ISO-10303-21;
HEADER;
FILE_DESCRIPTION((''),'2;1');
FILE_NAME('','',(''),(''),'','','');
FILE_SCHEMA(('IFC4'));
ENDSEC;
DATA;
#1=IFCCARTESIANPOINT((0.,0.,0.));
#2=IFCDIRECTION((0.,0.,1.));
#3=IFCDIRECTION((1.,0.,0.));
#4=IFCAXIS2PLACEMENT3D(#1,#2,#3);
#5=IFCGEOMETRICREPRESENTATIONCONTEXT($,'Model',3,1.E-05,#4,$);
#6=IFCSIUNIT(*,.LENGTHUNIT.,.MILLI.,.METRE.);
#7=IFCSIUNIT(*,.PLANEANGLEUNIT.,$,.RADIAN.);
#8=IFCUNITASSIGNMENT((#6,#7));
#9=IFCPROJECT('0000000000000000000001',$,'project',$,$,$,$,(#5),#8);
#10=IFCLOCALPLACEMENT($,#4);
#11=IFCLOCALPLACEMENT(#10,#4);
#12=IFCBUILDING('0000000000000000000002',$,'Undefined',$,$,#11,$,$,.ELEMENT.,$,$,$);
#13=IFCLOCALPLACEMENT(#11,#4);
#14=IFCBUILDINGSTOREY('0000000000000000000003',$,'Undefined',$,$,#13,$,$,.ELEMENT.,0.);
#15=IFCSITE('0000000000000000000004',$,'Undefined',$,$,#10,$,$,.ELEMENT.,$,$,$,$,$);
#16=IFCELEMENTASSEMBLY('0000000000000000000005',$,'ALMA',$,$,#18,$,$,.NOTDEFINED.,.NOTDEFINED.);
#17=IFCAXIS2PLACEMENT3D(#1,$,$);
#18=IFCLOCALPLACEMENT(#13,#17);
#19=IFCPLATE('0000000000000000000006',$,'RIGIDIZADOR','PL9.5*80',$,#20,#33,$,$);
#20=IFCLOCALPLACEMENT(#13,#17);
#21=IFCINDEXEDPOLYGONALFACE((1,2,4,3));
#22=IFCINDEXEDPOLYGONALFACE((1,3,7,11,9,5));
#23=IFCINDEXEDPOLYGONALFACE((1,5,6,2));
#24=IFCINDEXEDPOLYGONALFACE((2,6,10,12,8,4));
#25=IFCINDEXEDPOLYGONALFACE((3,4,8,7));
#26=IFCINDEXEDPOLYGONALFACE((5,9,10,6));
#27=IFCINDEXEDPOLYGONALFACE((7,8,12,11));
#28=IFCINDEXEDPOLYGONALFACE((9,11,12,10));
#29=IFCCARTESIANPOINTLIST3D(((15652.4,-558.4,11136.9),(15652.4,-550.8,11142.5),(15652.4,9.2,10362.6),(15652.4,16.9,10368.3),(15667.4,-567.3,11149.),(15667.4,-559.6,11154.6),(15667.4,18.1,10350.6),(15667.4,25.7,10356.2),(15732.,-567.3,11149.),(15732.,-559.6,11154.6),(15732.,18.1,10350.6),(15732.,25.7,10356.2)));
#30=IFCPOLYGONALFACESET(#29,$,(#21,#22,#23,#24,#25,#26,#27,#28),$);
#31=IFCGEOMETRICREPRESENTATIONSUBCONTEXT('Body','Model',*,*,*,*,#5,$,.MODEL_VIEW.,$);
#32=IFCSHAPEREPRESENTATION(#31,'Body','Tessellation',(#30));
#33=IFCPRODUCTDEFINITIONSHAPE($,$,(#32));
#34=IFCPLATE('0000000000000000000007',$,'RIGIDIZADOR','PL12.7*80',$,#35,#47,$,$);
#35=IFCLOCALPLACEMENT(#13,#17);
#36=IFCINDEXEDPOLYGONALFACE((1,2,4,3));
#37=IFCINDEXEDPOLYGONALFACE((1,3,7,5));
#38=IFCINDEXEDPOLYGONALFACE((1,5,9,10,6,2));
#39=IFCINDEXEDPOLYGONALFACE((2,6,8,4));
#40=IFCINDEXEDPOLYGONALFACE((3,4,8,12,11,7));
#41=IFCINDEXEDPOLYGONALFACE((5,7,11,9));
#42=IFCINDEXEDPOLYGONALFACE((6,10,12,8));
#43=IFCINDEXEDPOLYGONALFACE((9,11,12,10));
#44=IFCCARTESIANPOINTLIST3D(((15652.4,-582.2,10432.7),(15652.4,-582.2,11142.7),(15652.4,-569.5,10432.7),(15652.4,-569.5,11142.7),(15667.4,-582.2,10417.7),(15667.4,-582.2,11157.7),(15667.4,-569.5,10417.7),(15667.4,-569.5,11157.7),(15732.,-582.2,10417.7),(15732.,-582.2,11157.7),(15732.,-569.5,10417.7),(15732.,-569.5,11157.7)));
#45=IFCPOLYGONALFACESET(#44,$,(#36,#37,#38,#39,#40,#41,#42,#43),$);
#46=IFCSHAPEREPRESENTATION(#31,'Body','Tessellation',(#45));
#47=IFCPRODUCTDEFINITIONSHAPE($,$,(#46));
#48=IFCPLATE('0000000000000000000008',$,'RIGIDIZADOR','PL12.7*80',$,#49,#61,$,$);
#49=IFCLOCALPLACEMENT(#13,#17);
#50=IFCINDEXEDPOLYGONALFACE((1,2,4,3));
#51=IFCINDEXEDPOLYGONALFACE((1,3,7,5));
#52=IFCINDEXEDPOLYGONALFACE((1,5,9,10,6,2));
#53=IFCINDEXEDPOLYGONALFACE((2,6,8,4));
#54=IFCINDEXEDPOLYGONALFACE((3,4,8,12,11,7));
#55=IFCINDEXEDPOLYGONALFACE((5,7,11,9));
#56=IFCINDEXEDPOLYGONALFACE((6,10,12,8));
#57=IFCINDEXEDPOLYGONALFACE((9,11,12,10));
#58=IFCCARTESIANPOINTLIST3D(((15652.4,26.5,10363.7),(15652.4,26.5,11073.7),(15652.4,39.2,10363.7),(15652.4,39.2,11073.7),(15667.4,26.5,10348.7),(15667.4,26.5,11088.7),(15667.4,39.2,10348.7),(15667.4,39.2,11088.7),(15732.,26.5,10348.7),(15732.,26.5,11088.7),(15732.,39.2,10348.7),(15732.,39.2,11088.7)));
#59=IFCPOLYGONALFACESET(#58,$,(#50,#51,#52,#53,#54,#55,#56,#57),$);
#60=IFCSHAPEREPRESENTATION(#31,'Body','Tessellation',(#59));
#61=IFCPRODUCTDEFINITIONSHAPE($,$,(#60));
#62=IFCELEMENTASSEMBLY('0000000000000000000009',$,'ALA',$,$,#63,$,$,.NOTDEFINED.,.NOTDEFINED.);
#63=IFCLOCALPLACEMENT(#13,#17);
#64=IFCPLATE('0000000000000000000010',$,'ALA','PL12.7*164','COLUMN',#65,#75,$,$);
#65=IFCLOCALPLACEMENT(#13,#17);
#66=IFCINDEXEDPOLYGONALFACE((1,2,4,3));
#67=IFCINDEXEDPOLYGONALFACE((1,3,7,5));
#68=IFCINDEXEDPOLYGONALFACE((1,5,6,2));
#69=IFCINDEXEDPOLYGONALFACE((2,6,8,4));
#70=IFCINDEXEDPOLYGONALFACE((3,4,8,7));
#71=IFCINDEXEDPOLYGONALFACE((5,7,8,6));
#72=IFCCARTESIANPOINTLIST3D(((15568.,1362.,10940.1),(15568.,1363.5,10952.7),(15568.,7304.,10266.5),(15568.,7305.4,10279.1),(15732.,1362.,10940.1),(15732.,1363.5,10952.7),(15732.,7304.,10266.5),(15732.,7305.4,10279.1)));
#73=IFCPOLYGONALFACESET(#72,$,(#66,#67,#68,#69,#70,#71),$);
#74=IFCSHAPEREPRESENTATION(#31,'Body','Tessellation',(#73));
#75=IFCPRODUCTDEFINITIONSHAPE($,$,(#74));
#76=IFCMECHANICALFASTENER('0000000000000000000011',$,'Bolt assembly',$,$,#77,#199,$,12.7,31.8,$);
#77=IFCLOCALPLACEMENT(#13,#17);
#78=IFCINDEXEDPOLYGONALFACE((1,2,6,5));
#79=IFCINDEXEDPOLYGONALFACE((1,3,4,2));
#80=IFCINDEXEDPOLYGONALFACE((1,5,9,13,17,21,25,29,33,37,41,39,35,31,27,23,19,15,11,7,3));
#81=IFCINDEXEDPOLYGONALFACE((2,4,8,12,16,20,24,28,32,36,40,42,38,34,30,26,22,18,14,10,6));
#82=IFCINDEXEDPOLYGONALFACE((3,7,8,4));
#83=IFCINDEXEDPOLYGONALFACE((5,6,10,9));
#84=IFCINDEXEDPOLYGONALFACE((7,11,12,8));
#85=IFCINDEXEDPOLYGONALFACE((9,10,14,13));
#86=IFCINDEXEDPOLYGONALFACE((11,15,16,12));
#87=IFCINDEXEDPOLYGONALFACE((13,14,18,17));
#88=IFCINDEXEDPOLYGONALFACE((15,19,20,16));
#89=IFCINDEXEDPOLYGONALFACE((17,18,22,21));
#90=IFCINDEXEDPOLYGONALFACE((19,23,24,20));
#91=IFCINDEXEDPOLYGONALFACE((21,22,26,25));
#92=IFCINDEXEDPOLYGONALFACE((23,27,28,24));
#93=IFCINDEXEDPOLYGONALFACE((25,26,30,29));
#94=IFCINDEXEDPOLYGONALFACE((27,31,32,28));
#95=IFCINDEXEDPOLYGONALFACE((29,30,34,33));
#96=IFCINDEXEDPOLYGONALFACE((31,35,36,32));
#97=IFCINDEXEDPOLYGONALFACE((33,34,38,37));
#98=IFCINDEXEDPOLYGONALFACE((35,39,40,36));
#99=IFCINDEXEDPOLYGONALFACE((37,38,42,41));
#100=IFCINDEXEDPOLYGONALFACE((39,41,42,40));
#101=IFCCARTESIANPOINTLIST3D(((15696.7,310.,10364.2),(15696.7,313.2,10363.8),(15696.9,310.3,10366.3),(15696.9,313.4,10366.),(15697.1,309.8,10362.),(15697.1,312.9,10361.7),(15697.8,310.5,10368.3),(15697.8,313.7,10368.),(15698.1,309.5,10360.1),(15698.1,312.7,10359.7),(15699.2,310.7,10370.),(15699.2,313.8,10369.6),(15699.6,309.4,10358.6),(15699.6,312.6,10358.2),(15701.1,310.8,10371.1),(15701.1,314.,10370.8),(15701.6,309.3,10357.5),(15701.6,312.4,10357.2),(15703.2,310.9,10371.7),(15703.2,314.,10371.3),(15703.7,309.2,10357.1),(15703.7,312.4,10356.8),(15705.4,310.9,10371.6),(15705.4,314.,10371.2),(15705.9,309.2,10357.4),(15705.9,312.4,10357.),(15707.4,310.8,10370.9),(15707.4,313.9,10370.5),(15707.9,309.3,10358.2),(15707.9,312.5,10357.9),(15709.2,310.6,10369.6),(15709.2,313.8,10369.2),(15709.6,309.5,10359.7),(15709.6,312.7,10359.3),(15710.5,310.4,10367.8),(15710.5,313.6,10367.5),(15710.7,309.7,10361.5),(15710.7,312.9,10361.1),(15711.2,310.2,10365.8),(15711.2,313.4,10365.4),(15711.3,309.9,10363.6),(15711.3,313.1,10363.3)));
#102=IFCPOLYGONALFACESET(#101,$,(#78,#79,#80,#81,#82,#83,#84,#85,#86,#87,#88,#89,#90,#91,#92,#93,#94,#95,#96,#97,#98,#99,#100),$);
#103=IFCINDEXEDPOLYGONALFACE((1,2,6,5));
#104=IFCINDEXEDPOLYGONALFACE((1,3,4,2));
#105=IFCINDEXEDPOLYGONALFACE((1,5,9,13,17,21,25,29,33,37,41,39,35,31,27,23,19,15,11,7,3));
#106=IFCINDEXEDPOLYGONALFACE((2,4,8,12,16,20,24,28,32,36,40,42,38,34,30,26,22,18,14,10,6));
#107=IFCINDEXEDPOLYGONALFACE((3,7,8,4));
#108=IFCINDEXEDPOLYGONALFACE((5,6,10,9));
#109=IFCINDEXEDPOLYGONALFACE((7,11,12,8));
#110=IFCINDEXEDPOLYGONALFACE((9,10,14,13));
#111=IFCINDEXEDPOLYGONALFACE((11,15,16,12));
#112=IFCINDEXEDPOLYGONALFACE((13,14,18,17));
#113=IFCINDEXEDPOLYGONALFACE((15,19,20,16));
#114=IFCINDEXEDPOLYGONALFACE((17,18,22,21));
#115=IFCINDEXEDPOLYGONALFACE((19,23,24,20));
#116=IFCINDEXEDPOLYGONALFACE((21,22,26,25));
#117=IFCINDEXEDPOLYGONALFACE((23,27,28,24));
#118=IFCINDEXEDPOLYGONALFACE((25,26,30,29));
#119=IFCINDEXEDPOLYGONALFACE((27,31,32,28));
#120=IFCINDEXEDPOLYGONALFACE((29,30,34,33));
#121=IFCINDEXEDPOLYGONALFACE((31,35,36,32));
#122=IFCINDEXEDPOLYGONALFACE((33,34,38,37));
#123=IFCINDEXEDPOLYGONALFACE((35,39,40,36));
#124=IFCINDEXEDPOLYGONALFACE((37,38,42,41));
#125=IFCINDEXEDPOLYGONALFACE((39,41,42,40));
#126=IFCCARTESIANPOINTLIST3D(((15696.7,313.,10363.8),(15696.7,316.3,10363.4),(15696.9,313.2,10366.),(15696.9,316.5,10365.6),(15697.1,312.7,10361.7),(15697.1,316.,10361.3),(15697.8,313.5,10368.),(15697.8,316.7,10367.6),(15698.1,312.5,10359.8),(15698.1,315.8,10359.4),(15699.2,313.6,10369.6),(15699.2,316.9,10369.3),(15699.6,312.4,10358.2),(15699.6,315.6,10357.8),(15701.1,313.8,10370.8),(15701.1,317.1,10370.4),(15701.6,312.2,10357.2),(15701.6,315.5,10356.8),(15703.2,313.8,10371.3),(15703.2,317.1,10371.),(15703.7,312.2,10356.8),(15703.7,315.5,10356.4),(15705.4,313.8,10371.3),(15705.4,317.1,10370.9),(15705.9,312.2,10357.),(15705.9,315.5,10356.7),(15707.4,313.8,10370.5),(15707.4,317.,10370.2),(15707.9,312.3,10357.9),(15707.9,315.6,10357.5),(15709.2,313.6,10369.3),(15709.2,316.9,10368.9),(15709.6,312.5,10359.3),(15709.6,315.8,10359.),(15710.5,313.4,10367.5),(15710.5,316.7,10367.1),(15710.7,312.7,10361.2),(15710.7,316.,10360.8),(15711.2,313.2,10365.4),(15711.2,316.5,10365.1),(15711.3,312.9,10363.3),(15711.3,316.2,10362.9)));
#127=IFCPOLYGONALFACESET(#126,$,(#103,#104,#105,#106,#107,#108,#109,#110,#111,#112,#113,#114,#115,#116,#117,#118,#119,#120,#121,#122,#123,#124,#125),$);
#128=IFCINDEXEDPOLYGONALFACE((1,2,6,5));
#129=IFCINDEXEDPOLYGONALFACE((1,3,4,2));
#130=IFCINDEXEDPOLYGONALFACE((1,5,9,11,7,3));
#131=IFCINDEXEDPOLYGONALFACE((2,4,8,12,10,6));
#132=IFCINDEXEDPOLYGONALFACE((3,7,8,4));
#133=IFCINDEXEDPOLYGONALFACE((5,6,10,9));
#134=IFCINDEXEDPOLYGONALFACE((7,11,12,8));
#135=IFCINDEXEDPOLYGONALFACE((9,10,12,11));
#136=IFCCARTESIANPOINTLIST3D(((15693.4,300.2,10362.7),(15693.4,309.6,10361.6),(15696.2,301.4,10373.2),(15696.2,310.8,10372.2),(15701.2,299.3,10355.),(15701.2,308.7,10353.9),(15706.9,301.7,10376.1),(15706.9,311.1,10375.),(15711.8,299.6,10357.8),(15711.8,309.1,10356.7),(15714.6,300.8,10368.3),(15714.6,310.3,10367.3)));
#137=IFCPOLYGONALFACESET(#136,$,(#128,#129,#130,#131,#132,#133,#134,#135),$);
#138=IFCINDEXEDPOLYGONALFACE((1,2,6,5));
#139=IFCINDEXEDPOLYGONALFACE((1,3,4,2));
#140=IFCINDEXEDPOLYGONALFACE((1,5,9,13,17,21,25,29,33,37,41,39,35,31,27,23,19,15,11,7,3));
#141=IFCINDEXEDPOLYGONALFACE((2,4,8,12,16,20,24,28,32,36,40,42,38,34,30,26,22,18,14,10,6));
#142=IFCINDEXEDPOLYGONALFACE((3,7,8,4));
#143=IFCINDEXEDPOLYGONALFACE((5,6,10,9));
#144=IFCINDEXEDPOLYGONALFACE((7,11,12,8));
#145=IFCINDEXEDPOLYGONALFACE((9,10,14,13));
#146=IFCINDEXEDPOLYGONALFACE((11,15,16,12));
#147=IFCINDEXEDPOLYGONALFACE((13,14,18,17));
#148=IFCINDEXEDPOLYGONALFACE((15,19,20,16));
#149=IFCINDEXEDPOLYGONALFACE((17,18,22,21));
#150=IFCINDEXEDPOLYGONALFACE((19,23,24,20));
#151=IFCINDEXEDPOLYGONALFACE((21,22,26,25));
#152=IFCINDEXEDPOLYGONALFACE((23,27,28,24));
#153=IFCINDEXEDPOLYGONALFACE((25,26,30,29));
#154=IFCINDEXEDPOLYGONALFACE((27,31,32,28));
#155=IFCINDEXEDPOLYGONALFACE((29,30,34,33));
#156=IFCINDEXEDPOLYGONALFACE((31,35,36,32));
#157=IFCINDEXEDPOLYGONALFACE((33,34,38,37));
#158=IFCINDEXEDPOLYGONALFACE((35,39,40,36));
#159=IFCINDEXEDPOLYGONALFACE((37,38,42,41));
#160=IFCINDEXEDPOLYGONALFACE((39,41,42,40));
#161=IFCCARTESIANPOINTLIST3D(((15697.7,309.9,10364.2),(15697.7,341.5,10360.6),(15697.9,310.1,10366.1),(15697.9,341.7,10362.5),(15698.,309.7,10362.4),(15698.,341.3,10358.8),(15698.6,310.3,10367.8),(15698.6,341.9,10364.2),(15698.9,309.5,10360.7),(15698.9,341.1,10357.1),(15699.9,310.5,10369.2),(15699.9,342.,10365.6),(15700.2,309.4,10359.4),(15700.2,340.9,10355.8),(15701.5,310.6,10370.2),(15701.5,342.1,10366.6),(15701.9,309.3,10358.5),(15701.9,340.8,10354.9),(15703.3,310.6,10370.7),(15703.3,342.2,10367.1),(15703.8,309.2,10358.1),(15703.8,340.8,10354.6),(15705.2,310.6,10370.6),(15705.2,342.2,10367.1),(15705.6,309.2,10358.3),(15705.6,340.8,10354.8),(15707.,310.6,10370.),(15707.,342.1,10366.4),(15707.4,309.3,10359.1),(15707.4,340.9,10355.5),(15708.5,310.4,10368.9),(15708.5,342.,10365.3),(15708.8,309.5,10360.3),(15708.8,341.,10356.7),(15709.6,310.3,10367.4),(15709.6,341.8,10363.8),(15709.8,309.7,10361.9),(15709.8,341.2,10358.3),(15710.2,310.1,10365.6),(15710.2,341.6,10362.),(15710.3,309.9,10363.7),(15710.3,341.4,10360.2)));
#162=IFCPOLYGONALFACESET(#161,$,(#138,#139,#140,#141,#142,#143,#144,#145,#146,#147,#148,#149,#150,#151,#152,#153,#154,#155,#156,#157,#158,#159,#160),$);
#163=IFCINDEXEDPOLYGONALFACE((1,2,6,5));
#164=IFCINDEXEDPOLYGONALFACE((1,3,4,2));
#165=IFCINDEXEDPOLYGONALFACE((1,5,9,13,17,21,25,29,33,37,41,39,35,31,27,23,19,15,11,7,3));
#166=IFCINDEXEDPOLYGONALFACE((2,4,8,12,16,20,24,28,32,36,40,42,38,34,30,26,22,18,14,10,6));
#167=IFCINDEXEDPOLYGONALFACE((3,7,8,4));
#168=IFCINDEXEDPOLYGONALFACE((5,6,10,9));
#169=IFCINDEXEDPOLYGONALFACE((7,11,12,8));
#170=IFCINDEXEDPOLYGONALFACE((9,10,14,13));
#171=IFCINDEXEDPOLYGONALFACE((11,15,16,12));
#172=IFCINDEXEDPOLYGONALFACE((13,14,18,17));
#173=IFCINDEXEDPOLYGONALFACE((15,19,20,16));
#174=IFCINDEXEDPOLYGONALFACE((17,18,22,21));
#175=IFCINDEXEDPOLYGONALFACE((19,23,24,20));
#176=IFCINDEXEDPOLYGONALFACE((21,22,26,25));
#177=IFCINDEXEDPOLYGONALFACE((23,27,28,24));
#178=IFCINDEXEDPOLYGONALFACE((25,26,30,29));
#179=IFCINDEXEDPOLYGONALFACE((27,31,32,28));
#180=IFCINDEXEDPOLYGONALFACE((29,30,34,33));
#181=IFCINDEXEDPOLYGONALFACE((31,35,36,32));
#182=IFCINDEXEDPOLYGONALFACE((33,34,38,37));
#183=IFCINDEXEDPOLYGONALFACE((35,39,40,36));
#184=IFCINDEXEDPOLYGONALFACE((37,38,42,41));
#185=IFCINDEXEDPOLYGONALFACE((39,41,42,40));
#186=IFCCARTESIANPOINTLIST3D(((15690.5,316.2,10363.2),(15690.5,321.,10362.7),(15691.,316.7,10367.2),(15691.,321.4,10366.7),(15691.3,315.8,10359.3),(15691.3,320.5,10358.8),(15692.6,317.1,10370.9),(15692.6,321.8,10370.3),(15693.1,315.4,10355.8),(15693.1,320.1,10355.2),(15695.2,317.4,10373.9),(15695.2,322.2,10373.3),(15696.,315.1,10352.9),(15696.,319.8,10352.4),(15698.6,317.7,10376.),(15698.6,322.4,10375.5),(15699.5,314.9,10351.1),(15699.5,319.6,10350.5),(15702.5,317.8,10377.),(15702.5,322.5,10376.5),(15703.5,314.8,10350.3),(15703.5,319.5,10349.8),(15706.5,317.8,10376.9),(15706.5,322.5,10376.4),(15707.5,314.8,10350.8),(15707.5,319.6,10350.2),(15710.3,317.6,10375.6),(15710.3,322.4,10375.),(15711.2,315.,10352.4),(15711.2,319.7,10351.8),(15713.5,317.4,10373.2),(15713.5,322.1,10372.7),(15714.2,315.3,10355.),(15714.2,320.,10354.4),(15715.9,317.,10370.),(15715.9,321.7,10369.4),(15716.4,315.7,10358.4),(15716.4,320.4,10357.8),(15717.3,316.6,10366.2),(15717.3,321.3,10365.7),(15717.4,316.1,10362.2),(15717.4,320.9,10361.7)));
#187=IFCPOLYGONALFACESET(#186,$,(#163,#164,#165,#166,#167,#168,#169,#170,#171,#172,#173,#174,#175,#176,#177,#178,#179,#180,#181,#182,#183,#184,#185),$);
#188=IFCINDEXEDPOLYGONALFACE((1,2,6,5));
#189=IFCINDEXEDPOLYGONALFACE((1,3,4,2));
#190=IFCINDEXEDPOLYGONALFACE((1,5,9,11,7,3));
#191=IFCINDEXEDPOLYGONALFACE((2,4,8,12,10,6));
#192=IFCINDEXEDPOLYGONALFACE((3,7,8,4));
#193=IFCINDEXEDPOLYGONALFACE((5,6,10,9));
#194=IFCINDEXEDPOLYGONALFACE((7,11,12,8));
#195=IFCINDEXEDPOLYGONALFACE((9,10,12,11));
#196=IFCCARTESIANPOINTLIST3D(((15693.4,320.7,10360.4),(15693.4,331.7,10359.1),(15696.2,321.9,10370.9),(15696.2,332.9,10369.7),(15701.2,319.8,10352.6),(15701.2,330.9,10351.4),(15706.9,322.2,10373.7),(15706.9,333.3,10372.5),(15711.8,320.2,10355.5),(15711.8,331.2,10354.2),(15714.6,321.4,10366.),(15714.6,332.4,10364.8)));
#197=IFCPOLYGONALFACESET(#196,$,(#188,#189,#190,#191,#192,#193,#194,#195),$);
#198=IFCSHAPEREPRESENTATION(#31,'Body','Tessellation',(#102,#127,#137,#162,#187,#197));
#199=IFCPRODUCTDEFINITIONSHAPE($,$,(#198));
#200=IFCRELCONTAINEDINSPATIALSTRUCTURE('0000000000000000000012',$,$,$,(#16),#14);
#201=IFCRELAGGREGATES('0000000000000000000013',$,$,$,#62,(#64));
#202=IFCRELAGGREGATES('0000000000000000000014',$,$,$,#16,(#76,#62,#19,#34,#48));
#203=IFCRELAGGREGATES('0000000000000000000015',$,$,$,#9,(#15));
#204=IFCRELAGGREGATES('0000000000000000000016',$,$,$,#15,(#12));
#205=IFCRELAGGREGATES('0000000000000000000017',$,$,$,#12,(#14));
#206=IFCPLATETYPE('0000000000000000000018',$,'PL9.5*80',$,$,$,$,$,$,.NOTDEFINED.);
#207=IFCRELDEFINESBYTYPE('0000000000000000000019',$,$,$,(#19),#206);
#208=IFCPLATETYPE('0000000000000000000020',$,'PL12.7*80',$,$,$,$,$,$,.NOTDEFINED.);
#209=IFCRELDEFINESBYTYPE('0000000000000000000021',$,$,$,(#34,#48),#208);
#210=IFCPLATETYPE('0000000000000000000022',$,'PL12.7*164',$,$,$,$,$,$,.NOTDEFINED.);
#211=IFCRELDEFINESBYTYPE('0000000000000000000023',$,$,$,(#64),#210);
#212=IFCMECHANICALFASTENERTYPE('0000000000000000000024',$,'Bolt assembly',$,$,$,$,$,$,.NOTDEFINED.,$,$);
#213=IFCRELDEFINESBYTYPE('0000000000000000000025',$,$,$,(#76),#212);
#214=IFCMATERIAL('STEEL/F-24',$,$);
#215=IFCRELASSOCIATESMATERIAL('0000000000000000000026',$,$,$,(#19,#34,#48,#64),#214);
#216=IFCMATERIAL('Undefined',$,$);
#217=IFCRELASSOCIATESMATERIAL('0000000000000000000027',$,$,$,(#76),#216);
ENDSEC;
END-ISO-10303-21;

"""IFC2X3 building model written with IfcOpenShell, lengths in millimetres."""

from ifc_helpers import new_model, si_unit, frame, origin_with_axes, origin_2d_with_axis, place, context, subcontext, project, spatial, polyline, circle, outline, extrude, source, transform, mapped, material, type_object, element, aggregate, save


model = new_model("IFC2X3")

# Units and contexts
model_context = context("Model", 3, precision=1e-05, world=origin_with_axes())
body_context = subcontext(model_context, "Body", "Model", "MODEL_VIEW")
ifc_project = project(units=[si_unit("LENGTHUNIT", "METRE", prefix="MILLI"), si_unit("PLANEANGLEUNIT", "RADIAN")], contexts=[model_context])

# Site, building, storey
site_placement = place(None, origin_with_axes())
site = spatial("IfcSite", under=ifc_project, at=site_placement, Name="Undefined", CompositionType="ELEMENT")
building_placement = place(site_placement, origin_with_axes())
building = spatial("IfcBuilding", under=site, at=building_placement, Name="Undefined", CompositionType="ELEMENT")
storey_placement = place(building_placement, origin_with_axes())
storey = spatial("IfcBuildingStorey", under=building, at=storey_placement, Name="Undefined", CompositionType="ELEMENT", Elevation=0.0)

# Shared definitions
ifc_material_1 = material(Name="STEEL/F-24")

# Element assembly
assembly_1_placement = place(storey_placement, origin_with_axes())
assembly_1 = element("IfcElementAssembly", 1, at=assembly_1_placement, inside=storey, Name="ALMA", AssemblyPlace="NOTDEFINED", PredefinedType="NOTDEFINED")

# Plates
plate_type_1 = type_object("IfcPlateType", Name="PL9.5*80", PredefinedType="NOTDEFINED")
plate_1_placement = place(assembly_1_placement, frame((15732.0, -563.5, 11151.8), z_axis=(0.0, 0.806474, 0.59127), x_axis=(0.0, 0.59127, -0.806474)))
plate_1 = element("IfcPlate", 2, at=plate_1_placement, type_object=plate_type_1, material=ifc_material_1, Name="RIGIDIZADOR", Description="PL9.5*80", context=body_context, shape_type="SweptSolid", body=[
    extrude(outline(polyline([(0.0, 0.0), (990.0, 0.0), (990.0, 64.6), (975.0, 79.6), (15.0, 79.6), (0.0, 64.6), (0.0, 0.0)])), frame((0.0, 0.0, -4.8), z_axis=(0.0, 0.0, 1.0), x_axis=(1.0, 0.0, 0.0)), (0.0, 0.0, 1.0), 9.5),
])
plate_type_2 = type_object("IfcPlateType", Name="PL12.7*80", PredefinedType="NOTDEFINED")
plate_2_placement = place(assembly_1_placement, frame((15732.0, -575.9, 11157.7), z_axis=(0.0, 1.0, 0.0), x_axis=(0.0, 0.0, -1.0)))
plate_2 = element("IfcPlate", 3, at=plate_2_placement, type_object=plate_type_2, material=ifc_material_1, Name="RIGIDIZADOR", Description="PL12.7*80", context=body_context, shape_type="SweptSolid", body=[
    extrude(outline(polyline([(0.0, 0.0), (740.0, 0.0), (740.0, 64.6), (725.0, 79.6), (15.0, 79.6), (0.0, 64.6), (0.0, 0.0)])), frame((0.0, 0.0, -6.3), z_axis=(0.0, 0.0, 1.0), x_axis=(1.0, 0.0, 0.0)), (0.0, 0.0, 1.0), 12.7),
])
plate_3_placement = place(assembly_1_placement, frame((15732.0, 32.9, 11088.7), z_axis=(0.0, 1.0, 0.0), x_axis=(0.0, 0.0, -1.0)))
plate_3 = element("IfcPlate", 4, at=plate_3_placement, type_object=plate_type_2, material=ifc_material_1, Name="RIGIDIZADOR", Description="PL12.7*80", context=body_context, shape_type="SweptSolid", body=[
    extrude(outline(polyline([(0.0, 0.0), (740.0, 0.0), (740.0, 64.6), (725.0, 79.6), (15.0, 79.6), (0.0, 64.6), (0.0, 0.0)])), frame((0.0, 0.0, -6.3), z_axis=(0.0, 0.0, 1.0), x_axis=(1.0, 0.0, 0.0)), (0.0, 0.0, 1.0), 12.7),
])

# Element assembly, plate
assembly_2_placement = place(assembly_1_placement, origin_with_axes())
assembly_2 = element("IfcElementAssembly", 5, at=assembly_2_placement, Name="ALA", AssemblyPlace="NOTDEFINED", PredefinedType="NOTDEFINED")
plate_type_3 = type_object("IfcPlateType", Name="PL12.7*164", PredefinedType="NOTDEFINED")
plate_4_placement = place(assembly_2_placement, frame((15650.0, 1362.8, 10946.4), z_axis=(0.0, -0.112644, -0.993635), x_axis=(0.0, 0.993635, -0.112644)))
plate_4 = element("IfcPlate", 6, at=plate_4_placement, type_object=plate_type_3, material=ifc_material_1, Name="ALA", Description="PL12.7*164", ObjectType="COLUMN", context=body_context, shape_type="SweptSolid", body=[
    extrude(outline(polyline([(0.0, -82.0), (0.0, 82.0), (5980.0, 82.0), (5980.0, -82.0), (0.0, -82.0)])), frame((0.0, 0.0, -6.3), z_axis=(0.0, 0.0, 1.0), x_axis=(1.0, 0.0, 0.0)), (0.0, 0.0, 1.0), 12.7),
])
aggregate(assembly_2, [plate_4])

# Shared definitions
ifc_material_2 = material(Name="Undefined")
mechanical_fastener_type = type_object("IfcMechanicalFastenerType", Name="Bolt assembly")

# Mechanical fastener
shared_shape_1 = source(origin_with_axes(), body_context, "Body", "SweptSolid", [
    extrude(circle(Radius=7.3, at=origin_2d_with_axis()), frame((0.0, 0.1, 0.0), z_axis=(0.0, 1.0, 0.0), x_axis=(1.0, 0.0, 0.0)), (0.0, 0.0, 1.0), 3.2),
    extrude(circle(Radius=7.3, at=origin_2d_with_axis()), frame((0.0, 3.1, 0.0), z_axis=(0.0, 1.0, 0.0), x_axis=(1.0, 0.0, 0.0)), (0.0, 0.0, 1.0), 3.3),
    extrude(outline(polyline([(9.5, -5.5), (9.5, 5.5), (0.0, 11.0), (-9.5, 5.5), (-9.5, -5.5), (0.0, -11.0), (9.5, -5.5)])), frame((0.0, -9.5, 0.0), z_axis=(0.0, 1.0, 0.0), x_axis=(1.0, 0.0, 0.0)), (0.0, 0.0, 1.0), 9.5),
    extrude(circle(Radius=6.3, at=origin_2d_with_axis()), frame((0.0, 0.0, 0.0), z_axis=(0.0, 1.0, 0.0), x_axis=(1.0, 0.0, 0.0)), (0.0, 0.0, 1.0), 31.8),
    extrude(circle(Radius=13.5, at=origin_2d_with_axis()), frame((0.0, 6.4, 0.0), z_axis=(0.0, 1.0, 0.0), x_axis=(1.0, 0.0, 0.0)), (0.0, 0.0, 1.0), 4.8),
    extrude(outline(polyline([(9.5, -5.5), (9.5, 5.5), (0.0, 11.0), (-9.5, 5.5), (-9.5, -5.5), (0.0, -11.0), (9.5, -5.5)])), frame((0.0, 11.2, 0.0), z_axis=(0.0, 1.0, 0.0), x_axis=(1.0, 0.0, 0.0)), (0.0, 0.0, 1.0), 11.1),
])
mechanical_fastener_1_placement = place(assembly_1_placement, frame((15704.0, 309.9, 10364.4), z_axis=(-0.707107, 0.079651, 0.702606), x_axis=(0.707107, 0.079651, 0.702606)))
mechanical_fastener_1 = element("IfcMechanicalFastener", 7, at=mechanical_fastener_1_placement, type_object=mechanical_fastener_type, material=ifc_material_2, Name="Bolt assembly", NominalDiameter=12.7, NominalLength=31.8, context=body_context, shape_type="MappedRepresentation", body=[
    mapped(shared_shape_1, transform((0.0, 0.0, 0.0))),
])

aggregate(assembly_1, [mechanical_fastener_1, assembly_2, plate_1, plate_2, plate_3])

save(model, "model.ifc")
